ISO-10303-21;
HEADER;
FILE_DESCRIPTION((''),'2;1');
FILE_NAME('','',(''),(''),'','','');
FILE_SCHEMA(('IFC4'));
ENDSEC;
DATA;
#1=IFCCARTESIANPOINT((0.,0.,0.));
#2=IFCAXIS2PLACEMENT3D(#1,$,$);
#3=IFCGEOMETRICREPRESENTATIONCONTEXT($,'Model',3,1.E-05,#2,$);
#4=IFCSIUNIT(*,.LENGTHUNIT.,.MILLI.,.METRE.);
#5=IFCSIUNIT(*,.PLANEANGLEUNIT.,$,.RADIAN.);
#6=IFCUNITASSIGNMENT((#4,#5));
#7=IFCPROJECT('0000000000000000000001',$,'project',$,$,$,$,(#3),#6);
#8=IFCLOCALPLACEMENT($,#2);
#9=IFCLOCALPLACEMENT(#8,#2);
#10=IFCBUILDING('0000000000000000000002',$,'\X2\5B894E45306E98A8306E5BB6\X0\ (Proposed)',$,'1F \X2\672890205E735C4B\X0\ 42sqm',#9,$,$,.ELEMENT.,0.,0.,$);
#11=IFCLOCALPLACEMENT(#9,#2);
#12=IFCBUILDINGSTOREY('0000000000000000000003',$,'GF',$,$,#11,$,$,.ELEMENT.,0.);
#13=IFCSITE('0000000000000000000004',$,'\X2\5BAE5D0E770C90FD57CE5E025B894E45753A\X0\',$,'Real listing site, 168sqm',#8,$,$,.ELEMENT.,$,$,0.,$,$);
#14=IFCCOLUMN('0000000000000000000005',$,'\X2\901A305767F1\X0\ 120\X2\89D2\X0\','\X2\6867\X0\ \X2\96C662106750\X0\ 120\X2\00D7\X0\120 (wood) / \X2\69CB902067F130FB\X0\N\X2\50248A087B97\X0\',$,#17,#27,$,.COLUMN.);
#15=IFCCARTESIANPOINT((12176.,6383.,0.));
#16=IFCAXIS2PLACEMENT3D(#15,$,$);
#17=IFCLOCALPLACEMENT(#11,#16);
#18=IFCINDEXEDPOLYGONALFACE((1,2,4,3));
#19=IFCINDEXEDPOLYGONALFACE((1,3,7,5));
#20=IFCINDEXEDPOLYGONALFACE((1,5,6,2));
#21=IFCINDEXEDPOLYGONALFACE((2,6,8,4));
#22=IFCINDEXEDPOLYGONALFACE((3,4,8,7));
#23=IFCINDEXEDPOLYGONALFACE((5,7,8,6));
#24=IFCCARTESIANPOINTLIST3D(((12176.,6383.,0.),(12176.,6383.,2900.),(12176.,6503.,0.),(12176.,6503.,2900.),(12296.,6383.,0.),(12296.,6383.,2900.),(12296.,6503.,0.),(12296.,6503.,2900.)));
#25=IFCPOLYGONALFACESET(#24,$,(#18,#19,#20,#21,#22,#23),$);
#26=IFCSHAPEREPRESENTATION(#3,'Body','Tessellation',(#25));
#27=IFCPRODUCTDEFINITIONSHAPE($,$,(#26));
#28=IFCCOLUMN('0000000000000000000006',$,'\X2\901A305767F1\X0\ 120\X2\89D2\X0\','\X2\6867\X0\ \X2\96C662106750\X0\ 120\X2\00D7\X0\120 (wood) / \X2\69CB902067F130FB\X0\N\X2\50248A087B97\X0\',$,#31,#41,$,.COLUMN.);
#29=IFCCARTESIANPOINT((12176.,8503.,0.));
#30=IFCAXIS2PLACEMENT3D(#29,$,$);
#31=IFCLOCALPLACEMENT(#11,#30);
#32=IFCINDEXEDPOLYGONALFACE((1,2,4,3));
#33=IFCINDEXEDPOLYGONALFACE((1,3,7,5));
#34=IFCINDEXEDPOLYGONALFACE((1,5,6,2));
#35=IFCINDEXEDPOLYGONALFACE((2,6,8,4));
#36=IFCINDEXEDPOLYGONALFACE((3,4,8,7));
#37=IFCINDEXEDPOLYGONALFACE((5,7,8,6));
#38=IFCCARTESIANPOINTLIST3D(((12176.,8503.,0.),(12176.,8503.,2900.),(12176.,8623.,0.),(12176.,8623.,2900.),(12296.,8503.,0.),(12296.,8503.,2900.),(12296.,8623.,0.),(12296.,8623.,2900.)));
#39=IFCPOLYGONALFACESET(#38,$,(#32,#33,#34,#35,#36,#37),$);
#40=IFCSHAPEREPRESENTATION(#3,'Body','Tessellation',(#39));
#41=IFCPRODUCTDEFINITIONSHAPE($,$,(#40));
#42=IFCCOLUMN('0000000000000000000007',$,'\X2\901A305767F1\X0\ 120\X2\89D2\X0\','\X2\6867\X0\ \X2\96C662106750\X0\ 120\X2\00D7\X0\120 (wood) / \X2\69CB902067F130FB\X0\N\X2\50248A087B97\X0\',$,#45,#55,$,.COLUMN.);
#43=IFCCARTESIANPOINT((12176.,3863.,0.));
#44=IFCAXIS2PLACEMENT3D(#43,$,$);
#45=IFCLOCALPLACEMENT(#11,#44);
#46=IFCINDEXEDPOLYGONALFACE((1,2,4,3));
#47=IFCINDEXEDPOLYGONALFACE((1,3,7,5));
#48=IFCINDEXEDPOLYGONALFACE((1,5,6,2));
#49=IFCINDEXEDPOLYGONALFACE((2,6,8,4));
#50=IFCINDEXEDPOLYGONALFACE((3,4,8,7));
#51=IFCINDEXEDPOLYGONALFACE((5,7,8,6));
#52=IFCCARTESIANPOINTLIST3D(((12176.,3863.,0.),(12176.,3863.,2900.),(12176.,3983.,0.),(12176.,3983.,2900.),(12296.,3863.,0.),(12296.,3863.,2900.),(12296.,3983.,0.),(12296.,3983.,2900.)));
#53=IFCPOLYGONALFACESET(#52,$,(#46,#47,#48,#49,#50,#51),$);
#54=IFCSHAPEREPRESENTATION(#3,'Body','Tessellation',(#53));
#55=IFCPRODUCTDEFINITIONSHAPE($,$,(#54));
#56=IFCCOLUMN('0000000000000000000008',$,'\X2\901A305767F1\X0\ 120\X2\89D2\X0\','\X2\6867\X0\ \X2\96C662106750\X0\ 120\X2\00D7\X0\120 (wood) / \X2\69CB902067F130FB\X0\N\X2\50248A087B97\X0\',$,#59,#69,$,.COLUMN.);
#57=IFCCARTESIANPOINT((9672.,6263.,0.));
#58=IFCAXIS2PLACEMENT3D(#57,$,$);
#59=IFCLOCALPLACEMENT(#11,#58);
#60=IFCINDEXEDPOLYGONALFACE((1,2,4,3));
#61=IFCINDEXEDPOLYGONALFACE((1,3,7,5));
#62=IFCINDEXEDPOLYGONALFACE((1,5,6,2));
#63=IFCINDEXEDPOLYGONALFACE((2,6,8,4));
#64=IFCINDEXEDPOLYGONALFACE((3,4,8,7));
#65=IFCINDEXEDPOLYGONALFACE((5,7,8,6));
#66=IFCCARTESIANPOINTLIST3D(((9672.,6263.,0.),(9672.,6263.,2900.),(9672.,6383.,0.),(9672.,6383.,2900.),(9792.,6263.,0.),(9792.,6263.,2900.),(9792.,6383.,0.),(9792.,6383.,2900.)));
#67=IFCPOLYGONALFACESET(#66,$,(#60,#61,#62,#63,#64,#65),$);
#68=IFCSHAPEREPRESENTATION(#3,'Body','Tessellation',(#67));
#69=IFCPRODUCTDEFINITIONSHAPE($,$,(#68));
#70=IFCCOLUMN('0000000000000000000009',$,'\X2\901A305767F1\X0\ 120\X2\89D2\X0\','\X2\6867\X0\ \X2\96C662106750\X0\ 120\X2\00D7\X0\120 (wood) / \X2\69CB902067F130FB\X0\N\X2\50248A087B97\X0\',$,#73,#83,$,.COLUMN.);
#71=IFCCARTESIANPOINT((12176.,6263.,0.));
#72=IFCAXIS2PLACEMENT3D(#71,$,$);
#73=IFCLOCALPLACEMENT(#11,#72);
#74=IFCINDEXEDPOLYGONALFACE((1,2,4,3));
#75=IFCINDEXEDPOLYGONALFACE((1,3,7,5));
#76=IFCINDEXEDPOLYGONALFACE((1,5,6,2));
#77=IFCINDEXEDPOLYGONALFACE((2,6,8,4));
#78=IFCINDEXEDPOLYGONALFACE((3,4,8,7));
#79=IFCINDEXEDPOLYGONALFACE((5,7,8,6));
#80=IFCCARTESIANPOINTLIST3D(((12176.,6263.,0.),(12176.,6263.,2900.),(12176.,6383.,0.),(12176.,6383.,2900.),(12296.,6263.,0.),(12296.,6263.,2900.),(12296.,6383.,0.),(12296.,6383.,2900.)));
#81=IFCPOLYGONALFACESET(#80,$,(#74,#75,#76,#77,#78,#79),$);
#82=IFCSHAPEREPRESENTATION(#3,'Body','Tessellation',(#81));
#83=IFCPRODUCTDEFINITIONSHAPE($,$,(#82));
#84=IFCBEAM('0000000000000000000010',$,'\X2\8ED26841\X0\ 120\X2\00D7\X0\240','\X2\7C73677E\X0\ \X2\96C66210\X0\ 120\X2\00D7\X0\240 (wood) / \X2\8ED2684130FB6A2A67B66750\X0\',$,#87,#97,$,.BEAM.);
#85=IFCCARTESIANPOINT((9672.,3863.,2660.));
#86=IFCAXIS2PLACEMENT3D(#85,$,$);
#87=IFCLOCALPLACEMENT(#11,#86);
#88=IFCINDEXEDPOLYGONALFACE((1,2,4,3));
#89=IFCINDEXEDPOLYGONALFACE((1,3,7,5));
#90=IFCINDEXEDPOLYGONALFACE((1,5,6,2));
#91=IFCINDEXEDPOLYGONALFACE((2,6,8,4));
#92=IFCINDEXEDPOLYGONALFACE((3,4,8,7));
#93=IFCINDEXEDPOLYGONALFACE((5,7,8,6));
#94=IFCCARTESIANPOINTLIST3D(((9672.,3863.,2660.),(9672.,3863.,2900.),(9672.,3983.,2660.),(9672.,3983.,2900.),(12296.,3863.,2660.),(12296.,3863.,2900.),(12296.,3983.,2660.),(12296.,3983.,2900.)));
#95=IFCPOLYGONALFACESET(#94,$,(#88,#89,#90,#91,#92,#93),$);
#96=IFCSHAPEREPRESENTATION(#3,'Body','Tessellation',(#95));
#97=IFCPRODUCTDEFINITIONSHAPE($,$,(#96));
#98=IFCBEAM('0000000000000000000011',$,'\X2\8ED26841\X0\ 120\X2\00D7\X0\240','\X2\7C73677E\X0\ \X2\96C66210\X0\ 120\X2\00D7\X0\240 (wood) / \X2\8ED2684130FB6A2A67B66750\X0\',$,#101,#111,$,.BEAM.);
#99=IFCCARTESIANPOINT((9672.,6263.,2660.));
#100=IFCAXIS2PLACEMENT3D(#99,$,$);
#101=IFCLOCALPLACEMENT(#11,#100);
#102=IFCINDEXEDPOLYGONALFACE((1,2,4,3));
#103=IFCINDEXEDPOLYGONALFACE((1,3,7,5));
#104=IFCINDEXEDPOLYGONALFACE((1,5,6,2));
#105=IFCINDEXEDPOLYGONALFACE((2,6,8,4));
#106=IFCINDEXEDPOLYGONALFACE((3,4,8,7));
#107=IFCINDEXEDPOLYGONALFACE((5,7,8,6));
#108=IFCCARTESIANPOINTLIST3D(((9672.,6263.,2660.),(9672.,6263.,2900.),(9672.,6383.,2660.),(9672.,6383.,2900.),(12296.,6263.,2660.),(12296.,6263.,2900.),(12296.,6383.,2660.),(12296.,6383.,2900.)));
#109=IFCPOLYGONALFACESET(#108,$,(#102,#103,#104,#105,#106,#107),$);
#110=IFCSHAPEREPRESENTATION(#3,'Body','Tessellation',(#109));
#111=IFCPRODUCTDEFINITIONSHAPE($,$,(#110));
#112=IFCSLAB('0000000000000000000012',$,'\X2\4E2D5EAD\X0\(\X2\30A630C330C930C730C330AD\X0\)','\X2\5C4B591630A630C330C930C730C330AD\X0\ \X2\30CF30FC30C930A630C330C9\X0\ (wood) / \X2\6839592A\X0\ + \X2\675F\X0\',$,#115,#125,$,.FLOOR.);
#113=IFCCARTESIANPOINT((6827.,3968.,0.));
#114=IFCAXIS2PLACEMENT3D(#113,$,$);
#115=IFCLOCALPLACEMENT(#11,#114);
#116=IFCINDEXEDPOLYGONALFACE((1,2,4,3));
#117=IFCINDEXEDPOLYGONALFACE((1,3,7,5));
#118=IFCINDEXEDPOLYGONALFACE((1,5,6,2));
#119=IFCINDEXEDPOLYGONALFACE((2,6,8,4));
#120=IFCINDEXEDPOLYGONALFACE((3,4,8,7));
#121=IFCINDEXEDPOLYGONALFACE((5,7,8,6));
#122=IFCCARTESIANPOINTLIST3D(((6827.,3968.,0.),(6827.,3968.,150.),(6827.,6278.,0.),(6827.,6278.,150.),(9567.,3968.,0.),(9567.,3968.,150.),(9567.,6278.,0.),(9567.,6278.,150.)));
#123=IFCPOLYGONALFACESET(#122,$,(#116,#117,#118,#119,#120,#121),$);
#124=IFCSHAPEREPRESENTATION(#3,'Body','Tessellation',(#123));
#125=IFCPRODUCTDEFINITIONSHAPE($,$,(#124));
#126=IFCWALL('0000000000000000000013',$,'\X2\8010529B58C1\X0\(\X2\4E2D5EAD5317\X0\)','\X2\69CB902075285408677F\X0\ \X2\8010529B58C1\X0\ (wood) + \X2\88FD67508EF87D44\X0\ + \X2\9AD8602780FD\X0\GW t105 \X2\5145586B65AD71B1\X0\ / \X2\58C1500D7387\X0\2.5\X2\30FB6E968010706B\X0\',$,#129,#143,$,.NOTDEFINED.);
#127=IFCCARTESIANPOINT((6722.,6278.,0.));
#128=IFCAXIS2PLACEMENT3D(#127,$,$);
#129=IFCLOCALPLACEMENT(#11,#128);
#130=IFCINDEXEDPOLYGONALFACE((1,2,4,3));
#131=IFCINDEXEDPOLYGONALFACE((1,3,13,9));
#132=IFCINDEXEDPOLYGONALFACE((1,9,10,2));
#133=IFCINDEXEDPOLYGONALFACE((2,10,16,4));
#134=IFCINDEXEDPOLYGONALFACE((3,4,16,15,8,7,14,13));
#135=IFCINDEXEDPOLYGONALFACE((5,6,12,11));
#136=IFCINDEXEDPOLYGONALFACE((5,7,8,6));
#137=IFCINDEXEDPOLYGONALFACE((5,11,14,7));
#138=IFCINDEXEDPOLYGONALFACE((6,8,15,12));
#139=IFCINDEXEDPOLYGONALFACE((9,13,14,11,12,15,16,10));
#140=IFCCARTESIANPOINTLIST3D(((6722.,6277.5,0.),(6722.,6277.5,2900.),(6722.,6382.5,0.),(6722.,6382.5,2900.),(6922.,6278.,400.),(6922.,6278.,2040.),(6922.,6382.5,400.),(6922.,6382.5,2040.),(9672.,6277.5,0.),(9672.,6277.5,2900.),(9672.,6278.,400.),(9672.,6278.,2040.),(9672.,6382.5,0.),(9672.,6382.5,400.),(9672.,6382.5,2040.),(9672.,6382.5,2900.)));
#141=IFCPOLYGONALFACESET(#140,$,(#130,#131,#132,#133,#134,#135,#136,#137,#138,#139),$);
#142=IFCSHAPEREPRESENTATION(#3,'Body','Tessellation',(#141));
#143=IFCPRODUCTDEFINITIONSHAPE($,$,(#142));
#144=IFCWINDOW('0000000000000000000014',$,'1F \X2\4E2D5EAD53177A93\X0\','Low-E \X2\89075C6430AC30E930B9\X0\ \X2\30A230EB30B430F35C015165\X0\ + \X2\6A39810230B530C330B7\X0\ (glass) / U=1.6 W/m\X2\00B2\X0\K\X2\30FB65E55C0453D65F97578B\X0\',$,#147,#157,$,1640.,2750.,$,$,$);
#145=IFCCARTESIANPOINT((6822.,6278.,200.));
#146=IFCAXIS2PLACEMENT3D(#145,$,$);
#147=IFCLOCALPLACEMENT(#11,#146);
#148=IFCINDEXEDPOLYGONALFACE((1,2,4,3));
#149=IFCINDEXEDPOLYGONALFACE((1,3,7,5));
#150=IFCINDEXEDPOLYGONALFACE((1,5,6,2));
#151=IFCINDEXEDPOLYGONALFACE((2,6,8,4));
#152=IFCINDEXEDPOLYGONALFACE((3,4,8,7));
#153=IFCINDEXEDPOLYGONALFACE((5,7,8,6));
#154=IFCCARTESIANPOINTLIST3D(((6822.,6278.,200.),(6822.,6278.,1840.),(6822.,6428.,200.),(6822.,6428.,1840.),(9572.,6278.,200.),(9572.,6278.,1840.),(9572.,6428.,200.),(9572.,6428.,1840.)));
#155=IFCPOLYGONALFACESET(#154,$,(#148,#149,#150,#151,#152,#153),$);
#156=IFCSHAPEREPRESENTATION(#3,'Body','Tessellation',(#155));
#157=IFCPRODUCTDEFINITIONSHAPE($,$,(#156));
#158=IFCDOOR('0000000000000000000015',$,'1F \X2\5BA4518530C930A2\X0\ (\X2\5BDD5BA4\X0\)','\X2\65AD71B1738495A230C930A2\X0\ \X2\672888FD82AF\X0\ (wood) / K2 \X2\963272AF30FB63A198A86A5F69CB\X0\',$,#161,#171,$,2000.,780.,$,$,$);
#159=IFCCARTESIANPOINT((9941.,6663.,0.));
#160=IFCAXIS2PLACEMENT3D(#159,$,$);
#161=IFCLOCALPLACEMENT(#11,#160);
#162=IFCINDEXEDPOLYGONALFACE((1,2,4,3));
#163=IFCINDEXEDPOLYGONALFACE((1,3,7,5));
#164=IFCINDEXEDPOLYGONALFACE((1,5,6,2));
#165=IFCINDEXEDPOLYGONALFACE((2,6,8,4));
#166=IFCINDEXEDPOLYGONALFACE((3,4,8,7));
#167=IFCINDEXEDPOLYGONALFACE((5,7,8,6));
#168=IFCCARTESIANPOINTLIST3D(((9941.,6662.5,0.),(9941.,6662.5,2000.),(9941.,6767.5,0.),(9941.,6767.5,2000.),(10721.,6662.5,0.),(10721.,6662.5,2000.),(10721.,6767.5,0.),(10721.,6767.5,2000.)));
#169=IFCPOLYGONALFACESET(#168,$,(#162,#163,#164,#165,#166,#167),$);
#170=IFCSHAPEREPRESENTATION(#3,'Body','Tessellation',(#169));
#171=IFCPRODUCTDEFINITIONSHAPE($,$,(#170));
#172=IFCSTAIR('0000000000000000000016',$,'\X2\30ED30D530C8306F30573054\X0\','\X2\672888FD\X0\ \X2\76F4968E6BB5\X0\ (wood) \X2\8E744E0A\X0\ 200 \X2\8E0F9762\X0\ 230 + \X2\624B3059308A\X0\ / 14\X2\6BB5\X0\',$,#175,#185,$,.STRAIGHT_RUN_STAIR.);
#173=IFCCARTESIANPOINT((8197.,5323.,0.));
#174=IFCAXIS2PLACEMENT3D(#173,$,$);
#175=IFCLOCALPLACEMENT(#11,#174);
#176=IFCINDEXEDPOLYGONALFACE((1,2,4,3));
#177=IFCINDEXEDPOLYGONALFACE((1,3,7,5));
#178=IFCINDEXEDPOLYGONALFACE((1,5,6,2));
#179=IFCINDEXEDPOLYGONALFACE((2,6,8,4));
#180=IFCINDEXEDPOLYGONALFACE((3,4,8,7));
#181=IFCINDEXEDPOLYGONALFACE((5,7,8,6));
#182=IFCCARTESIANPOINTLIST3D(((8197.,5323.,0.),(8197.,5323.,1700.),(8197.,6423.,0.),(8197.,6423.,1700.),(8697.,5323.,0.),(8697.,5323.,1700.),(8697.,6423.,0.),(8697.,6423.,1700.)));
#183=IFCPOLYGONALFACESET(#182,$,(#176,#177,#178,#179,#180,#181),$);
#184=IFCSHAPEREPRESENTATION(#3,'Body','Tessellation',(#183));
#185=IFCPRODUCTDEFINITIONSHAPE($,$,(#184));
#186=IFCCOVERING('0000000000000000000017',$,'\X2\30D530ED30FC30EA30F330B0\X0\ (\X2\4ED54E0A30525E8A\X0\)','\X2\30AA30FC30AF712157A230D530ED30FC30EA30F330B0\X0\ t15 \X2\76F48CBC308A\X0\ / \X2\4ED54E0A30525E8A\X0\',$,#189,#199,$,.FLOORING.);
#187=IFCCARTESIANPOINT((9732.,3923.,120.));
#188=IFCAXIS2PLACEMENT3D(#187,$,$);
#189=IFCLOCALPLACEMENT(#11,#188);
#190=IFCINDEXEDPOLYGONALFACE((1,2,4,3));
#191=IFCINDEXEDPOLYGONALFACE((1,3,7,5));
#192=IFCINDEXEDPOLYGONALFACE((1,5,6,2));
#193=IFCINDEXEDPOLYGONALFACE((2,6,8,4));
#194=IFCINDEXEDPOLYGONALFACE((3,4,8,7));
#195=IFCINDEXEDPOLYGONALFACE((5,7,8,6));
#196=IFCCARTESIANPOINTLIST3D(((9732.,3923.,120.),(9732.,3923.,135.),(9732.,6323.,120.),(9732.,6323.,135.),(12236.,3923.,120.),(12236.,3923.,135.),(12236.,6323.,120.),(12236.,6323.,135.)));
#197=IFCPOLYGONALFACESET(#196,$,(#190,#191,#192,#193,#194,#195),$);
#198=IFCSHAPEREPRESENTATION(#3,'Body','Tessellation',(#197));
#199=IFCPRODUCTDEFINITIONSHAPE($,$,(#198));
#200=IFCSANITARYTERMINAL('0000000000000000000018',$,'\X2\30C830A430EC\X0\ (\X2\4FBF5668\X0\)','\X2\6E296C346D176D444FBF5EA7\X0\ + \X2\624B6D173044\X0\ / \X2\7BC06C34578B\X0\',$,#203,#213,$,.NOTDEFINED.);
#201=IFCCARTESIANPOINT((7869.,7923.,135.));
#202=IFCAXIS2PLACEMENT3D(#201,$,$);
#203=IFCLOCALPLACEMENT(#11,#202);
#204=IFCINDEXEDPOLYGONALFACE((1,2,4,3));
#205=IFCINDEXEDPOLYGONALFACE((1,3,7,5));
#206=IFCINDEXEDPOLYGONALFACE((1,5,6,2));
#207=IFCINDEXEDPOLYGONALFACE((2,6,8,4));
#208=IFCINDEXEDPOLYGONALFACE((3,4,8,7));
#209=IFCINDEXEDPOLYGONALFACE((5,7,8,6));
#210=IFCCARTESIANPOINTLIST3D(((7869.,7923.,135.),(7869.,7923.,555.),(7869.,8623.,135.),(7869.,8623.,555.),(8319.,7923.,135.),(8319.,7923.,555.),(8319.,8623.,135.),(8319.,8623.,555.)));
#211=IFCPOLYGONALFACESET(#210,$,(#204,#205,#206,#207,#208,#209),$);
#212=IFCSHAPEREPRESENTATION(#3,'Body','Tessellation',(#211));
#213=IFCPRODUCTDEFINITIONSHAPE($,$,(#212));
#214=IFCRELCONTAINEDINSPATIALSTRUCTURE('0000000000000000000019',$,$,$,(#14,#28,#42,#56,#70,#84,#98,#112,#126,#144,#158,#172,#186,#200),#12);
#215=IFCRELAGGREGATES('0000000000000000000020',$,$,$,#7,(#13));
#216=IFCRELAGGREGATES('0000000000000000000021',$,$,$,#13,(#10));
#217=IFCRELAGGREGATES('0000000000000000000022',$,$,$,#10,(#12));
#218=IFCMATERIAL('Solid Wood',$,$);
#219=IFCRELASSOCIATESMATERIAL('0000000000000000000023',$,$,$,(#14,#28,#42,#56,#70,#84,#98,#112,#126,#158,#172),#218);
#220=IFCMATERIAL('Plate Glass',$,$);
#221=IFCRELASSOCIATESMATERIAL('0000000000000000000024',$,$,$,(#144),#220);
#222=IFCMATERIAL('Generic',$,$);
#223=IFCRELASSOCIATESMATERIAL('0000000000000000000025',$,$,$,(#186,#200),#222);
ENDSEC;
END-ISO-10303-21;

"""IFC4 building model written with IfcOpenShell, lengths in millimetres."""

from ifc_helpers import new_model, si_unit, frame, frame_2d, origin, place, context, project, spatial, rectangle, extrude, material, element, fill, save


model = new_model("IFC4")

# Units and contexts
model_context = context("Model", 3, precision=1e-05, world=origin())
ifc_project = project(units=[si_unit("LENGTHUNIT", "METRE", prefix="MILLI"), si_unit("PLANEANGLEUNIT", "RADIAN")], contexts=[model_context])

# Site, building, storey
site_placement = place(None, origin())
site = spatial("IfcSite", under=ifc_project, at=site_placement, Name="宮崎県都城市安久町", ObjectType="Real listing site, 168sqm", CompositionType="ELEMENT", RefElevation=0.0)
building_placement = place(site_placement, origin())
building = spatial("IfcBuilding", under=site, at=building_placement, Name="安久の風の家 (Proposed)", ObjectType="1F 木造平屋 42sqm", CompositionType="ELEMENT", ElevationOfRefHeight=0.0, ElevationOfTerrain=0.0)
storey_placement = place(building_placement, origin())
storey = spatial("IfcBuildingStorey", under=building, at=storey_placement, Name="GF", CompositionType="ELEMENT", Elevation=0.0)

# Columns
ifc_material_1 = material(Name="Solid Wood")
column_1_placement = place(storey_placement, frame((12176.0, 6383.0, 0.0)))
element("IfcColumn", 1, at=column_1_placement, inside=storey, material=ifc_material_1, Name="通し柱 120角", Description="桧 集成材 120×120 (wood) / 構造柱・N値計算", PredefinedType="COLUMN", context=model_context, shape_type="SweptSolid", body=[
    extrude(rectangle(XDim=120.0, YDim=120.0, at=frame_2d((60.0, 60.0))), frame((12176.0, 6383.0, 0.0)), (0.0, 0.0, 1.0), 2900.0),
])
column_2_placement = place(storey_placement, frame((12176.0, 8503.0, 0.0)))
element("IfcColumn", 2, at=column_2_placement, inside=storey, material=ifc_material_1, Name="通し柱 120角", Description="桧 集成材 120×120 (wood) / 構造柱・N値計算", PredefinedType="COLUMN", context=model_context, shape_type="SweptSolid", body=[
    extrude(rectangle(XDim=120.0, YDim=120.0, at=frame_2d((60.0, 60.0))), frame((12176.0, 8503.0, 0.0)), (0.0, 0.0, 1.0), 2900.0),
])
column_3_placement = place(storey_placement, frame((12176.0, 3863.0, 0.0)))
element("IfcColumn", 3, at=column_3_placement, inside=storey, material=ifc_material_1, Name="通し柱 120角", Description="桧 集成材 120×120 (wood) / 構造柱・N値計算", PredefinedType="COLUMN", context=model_context, shape_type="SweptSolid", body=[
    extrude(rectangle(XDim=120.0, YDim=120.0, at=frame_2d((60.0, 60.0))), frame((12176.0, 3863.0, 0.0)), (0.0, 0.0, 1.0), 2900.0),
])
column_4_placement = place(storey_placement, frame((9672.0, 6263.0, 0.0)))
element("IfcColumn", 4, at=column_4_placement, inside=storey, material=ifc_material_1, Name="通し柱 120角", Description="桧 集成材 120×120 (wood) / 構造柱・N値計算", PredefinedType="COLUMN", context=model_context, shape_type="SweptSolid", body=[
    extrude(rectangle(XDim=120.0, YDim=120.0, at=frame_2d((60.0, 60.0))), frame((9672.0, 6263.0, 0.0)), (0.0, 0.0, 1.0), 2900.0),
])
column_5_placement = place(storey_placement, frame((12176.0, 6263.0, 0.0)))
element("IfcColumn", 5, at=column_5_placement, inside=storey, material=ifc_material_1, Name="通し柱 120角", Description="桧 集成材 120×120 (wood) / 構造柱・N値計算", PredefinedType="COLUMN", context=model_context, shape_type="SweptSolid", body=[
    extrude(rectangle(XDim=120.0, YDim=120.0, at=frame_2d((60.0, 60.0))), frame((12176.0, 6263.0, 0.0)), (0.0, 0.0, 1.0), 2900.0),
])

# Beams
beam_1_placement = place(storey_placement, frame((9672.0, 3863.0, 2660.0)))
element("IfcBeam", 6, at=beam_1_placement, inside=storey, material=ifc_material_1, Name="軒桁 120×240", Description="米松 集成 120×240 (wood) / 軒桁・横架材", PredefinedType="BEAM", context=model_context, shape_type="SweptSolid", body=[
    extrude(rectangle(XDim=2624.0, YDim=120.0, at=frame_2d((1312.0, 60.0))), frame((9672.0, 3863.0, 2660.0)), (0.0, 0.0, 1.0), 240.0),
])
beam_2_placement = place(storey_placement, frame((9672.0, 6263.0, 2660.0)))
element("IfcBeam", 7, at=beam_2_placement, inside=storey, material=ifc_material_1, Name="軒桁 120×240", Description="米松 集成 120×240 (wood) / 軒桁・横架材", PredefinedType="BEAM", context=model_context, shape_type="SweptSolid", body=[
    extrude(rectangle(XDim=2624.0, YDim=120.0, at=frame_2d((1312.0, 60.0))), frame((9672.0, 6263.0, 2660.0)), (0.0, 0.0, 1.0), 240.0),
])

# Slab
slab_placement = place(storey_placement, frame((6827.0, 3968.0, 0.0)))
element("IfcSlab", 8, at=slab_placement, inside=storey, material=ifc_material_1, Name="中庭(ウッドデッキ)", Description="屋外ウッドデッキ ハードウッド (wood) / 根太 + 束", PredefinedType="FLOOR", context=model_context, shape_type="SweptSolid", body=[
    extrude(rectangle(XDim=2740.0, YDim=2310.0, at=frame_2d((1370.0, 1155.0))), frame((6827.0, 3968.0, 0.0)), (0.0, 0.0, 1.0), 150.0),
])

# Wall, opening, window
wall_1_placement = place(storey_placement, frame((6722.0, 6278.0, 0.0)))
wall_1 = element("IfcWall", 9, at=wall_1_placement, inside=storey, material=ifc_material_1, Name="耐力壁(中庭北)", Description="構造用合板 耐力壁 (wood) + 製材軸組 + 高性能GW t105 充填断熱 / 壁倍率2.5・準耐火", PredefinedType="NOTDEFINED", context=model_context, shape_type="SweptSolid", body=[
    extrude(rectangle(XDim=2950.0, YDim=105.0, at=frame_2d((1475.0, 52.0))), frame((6722.0, 6278.0, 0.0)), (0.0, 0.0, 1.0), 2900.0),
])
opening_placement = place(storey_placement, frame((6822.0, 6278.0, 200.0)))
opening = element("IfcOpeningElement", 10, at=opening_placement, cuts=wall_1, PredefinedType="NOTDEFINED", context=model_context, shape_type="SweptSolid", body=[
    extrude(rectangle(XDim=2750.0, YDim=150.0, at=frame_2d((1375.0, 75.0))), frame((6822.0, 6278.0, 200.0)), (0.0, 0.0, 1.0), 1640.0),
])
ifc_material_2 = material(Name="Plate Glass")
window_placement = place(storey_placement, frame((6822.0, 6278.0, 200.0)))
window = element("IfcWindow", 11, at=window_placement, inside=storey, material=ifc_material_2, Name="1F 中庭北窓", Description="Low-E 複層ガラス アルゴン封入 + 樹脂サッシ (glass) / U=1.6 W/m²K・日射取得型", OverallHeight=1640.0, OverallWidth=2750.0, context=model_context, shape_type="SweptSolid", body=[
    extrude(rectangle(XDim=2750.0, YDim=150.0, at=frame_2d((1375.0, 75.0))), frame((6822.0, 6278.0, 200.0)), (0.0, 0.0, 1.0), 1640.0),
])
fill(opening, window)

# Door
door_placement = place(storey_placement, frame((9941.0, 6663.0, 0.0)))
element("IfcDoor", 12, at=door_placement, inside=storey, material=ifc_material_1, Name="1F 室内ドア (寝室)", Description="断熱玄関ドア 木製芯 (wood) / K2 防犯・採風機構", OverallHeight=2000.0, OverallWidth=780.0, context=model_context, shape_type="SweptSolid", body=[
    extrude(rectangle(XDim=780.0, YDim=105.0, at=frame_2d((390.0, 52.0))), frame((9941.0, 6663.0, 0.0)), (0.0, 0.0, 1.0), 2000.0),
])

# Stair
stair_placement = place(storey_placement, frame((8197.0, 5323.0, 0.0)))
element("IfcStair", 13, at=stair_placement, inside=storey, material=ifc_material_1, Name="ロフトはしご", Description="木製 直階段 (wood) 蹴上 200 踏面 230 + 手すり / 14段", PredefinedType="STRAIGHT_RUN_STAIR", context=model_context, shape_type="SweptSolid", body=[
    extrude(rectangle(XDim=500.0, YDim=1100.0, at=frame_2d((250.0, 550.0))), frame((8197.0, 5323.0, 0.0)), (0.0, 0.0, 1.0), 1700.0),
])

# Covering
ifc_material_3 = material(Name="Generic")
covering_placement = place(storey_placement, frame((9732.0, 3923.0, 120.0)))
element("IfcCovering", 14, at=covering_placement, inside=storey, material=ifc_material_3, Name="フローリング (仕上げ床)", Description="オーク無垢フローリング t15 直貼り / 仕上げ床", PredefinedType="FLOORING", context=model_context, shape_type="SweptSolid", body=[
    extrude(rectangle(XDim=2504.0, YDim=2400.0, at=frame_2d((1252.0, 1200.0))), frame((9732.0, 3923.0, 120.0)), (0.0, 0.0, 1.0), 15.0),
])

# Sanitary terminal
sanitary_terminal_placement = place(storey_placement, frame((7869.0, 7923.0, 135.0)))
element("IfcSanitaryTerminal", 15, at=sanitary_terminal_placement, inside=storey, material=ifc_material_3, Name="トイレ (便器)", Description="温水洗浄便座 + 手洗い / 節水型", PredefinedType="NOTDEFINED", context=model_context, shape_type="SweptSolid", body=[
    extrude(rectangle(XDim=450.0, YDim=700.0, at=frame_2d((225.0, 350.0))), frame((7869.0, 7923.0, 135.0)), (0.0, 0.0, 1.0), 420.0),
])

save(model, "model.ifc")
